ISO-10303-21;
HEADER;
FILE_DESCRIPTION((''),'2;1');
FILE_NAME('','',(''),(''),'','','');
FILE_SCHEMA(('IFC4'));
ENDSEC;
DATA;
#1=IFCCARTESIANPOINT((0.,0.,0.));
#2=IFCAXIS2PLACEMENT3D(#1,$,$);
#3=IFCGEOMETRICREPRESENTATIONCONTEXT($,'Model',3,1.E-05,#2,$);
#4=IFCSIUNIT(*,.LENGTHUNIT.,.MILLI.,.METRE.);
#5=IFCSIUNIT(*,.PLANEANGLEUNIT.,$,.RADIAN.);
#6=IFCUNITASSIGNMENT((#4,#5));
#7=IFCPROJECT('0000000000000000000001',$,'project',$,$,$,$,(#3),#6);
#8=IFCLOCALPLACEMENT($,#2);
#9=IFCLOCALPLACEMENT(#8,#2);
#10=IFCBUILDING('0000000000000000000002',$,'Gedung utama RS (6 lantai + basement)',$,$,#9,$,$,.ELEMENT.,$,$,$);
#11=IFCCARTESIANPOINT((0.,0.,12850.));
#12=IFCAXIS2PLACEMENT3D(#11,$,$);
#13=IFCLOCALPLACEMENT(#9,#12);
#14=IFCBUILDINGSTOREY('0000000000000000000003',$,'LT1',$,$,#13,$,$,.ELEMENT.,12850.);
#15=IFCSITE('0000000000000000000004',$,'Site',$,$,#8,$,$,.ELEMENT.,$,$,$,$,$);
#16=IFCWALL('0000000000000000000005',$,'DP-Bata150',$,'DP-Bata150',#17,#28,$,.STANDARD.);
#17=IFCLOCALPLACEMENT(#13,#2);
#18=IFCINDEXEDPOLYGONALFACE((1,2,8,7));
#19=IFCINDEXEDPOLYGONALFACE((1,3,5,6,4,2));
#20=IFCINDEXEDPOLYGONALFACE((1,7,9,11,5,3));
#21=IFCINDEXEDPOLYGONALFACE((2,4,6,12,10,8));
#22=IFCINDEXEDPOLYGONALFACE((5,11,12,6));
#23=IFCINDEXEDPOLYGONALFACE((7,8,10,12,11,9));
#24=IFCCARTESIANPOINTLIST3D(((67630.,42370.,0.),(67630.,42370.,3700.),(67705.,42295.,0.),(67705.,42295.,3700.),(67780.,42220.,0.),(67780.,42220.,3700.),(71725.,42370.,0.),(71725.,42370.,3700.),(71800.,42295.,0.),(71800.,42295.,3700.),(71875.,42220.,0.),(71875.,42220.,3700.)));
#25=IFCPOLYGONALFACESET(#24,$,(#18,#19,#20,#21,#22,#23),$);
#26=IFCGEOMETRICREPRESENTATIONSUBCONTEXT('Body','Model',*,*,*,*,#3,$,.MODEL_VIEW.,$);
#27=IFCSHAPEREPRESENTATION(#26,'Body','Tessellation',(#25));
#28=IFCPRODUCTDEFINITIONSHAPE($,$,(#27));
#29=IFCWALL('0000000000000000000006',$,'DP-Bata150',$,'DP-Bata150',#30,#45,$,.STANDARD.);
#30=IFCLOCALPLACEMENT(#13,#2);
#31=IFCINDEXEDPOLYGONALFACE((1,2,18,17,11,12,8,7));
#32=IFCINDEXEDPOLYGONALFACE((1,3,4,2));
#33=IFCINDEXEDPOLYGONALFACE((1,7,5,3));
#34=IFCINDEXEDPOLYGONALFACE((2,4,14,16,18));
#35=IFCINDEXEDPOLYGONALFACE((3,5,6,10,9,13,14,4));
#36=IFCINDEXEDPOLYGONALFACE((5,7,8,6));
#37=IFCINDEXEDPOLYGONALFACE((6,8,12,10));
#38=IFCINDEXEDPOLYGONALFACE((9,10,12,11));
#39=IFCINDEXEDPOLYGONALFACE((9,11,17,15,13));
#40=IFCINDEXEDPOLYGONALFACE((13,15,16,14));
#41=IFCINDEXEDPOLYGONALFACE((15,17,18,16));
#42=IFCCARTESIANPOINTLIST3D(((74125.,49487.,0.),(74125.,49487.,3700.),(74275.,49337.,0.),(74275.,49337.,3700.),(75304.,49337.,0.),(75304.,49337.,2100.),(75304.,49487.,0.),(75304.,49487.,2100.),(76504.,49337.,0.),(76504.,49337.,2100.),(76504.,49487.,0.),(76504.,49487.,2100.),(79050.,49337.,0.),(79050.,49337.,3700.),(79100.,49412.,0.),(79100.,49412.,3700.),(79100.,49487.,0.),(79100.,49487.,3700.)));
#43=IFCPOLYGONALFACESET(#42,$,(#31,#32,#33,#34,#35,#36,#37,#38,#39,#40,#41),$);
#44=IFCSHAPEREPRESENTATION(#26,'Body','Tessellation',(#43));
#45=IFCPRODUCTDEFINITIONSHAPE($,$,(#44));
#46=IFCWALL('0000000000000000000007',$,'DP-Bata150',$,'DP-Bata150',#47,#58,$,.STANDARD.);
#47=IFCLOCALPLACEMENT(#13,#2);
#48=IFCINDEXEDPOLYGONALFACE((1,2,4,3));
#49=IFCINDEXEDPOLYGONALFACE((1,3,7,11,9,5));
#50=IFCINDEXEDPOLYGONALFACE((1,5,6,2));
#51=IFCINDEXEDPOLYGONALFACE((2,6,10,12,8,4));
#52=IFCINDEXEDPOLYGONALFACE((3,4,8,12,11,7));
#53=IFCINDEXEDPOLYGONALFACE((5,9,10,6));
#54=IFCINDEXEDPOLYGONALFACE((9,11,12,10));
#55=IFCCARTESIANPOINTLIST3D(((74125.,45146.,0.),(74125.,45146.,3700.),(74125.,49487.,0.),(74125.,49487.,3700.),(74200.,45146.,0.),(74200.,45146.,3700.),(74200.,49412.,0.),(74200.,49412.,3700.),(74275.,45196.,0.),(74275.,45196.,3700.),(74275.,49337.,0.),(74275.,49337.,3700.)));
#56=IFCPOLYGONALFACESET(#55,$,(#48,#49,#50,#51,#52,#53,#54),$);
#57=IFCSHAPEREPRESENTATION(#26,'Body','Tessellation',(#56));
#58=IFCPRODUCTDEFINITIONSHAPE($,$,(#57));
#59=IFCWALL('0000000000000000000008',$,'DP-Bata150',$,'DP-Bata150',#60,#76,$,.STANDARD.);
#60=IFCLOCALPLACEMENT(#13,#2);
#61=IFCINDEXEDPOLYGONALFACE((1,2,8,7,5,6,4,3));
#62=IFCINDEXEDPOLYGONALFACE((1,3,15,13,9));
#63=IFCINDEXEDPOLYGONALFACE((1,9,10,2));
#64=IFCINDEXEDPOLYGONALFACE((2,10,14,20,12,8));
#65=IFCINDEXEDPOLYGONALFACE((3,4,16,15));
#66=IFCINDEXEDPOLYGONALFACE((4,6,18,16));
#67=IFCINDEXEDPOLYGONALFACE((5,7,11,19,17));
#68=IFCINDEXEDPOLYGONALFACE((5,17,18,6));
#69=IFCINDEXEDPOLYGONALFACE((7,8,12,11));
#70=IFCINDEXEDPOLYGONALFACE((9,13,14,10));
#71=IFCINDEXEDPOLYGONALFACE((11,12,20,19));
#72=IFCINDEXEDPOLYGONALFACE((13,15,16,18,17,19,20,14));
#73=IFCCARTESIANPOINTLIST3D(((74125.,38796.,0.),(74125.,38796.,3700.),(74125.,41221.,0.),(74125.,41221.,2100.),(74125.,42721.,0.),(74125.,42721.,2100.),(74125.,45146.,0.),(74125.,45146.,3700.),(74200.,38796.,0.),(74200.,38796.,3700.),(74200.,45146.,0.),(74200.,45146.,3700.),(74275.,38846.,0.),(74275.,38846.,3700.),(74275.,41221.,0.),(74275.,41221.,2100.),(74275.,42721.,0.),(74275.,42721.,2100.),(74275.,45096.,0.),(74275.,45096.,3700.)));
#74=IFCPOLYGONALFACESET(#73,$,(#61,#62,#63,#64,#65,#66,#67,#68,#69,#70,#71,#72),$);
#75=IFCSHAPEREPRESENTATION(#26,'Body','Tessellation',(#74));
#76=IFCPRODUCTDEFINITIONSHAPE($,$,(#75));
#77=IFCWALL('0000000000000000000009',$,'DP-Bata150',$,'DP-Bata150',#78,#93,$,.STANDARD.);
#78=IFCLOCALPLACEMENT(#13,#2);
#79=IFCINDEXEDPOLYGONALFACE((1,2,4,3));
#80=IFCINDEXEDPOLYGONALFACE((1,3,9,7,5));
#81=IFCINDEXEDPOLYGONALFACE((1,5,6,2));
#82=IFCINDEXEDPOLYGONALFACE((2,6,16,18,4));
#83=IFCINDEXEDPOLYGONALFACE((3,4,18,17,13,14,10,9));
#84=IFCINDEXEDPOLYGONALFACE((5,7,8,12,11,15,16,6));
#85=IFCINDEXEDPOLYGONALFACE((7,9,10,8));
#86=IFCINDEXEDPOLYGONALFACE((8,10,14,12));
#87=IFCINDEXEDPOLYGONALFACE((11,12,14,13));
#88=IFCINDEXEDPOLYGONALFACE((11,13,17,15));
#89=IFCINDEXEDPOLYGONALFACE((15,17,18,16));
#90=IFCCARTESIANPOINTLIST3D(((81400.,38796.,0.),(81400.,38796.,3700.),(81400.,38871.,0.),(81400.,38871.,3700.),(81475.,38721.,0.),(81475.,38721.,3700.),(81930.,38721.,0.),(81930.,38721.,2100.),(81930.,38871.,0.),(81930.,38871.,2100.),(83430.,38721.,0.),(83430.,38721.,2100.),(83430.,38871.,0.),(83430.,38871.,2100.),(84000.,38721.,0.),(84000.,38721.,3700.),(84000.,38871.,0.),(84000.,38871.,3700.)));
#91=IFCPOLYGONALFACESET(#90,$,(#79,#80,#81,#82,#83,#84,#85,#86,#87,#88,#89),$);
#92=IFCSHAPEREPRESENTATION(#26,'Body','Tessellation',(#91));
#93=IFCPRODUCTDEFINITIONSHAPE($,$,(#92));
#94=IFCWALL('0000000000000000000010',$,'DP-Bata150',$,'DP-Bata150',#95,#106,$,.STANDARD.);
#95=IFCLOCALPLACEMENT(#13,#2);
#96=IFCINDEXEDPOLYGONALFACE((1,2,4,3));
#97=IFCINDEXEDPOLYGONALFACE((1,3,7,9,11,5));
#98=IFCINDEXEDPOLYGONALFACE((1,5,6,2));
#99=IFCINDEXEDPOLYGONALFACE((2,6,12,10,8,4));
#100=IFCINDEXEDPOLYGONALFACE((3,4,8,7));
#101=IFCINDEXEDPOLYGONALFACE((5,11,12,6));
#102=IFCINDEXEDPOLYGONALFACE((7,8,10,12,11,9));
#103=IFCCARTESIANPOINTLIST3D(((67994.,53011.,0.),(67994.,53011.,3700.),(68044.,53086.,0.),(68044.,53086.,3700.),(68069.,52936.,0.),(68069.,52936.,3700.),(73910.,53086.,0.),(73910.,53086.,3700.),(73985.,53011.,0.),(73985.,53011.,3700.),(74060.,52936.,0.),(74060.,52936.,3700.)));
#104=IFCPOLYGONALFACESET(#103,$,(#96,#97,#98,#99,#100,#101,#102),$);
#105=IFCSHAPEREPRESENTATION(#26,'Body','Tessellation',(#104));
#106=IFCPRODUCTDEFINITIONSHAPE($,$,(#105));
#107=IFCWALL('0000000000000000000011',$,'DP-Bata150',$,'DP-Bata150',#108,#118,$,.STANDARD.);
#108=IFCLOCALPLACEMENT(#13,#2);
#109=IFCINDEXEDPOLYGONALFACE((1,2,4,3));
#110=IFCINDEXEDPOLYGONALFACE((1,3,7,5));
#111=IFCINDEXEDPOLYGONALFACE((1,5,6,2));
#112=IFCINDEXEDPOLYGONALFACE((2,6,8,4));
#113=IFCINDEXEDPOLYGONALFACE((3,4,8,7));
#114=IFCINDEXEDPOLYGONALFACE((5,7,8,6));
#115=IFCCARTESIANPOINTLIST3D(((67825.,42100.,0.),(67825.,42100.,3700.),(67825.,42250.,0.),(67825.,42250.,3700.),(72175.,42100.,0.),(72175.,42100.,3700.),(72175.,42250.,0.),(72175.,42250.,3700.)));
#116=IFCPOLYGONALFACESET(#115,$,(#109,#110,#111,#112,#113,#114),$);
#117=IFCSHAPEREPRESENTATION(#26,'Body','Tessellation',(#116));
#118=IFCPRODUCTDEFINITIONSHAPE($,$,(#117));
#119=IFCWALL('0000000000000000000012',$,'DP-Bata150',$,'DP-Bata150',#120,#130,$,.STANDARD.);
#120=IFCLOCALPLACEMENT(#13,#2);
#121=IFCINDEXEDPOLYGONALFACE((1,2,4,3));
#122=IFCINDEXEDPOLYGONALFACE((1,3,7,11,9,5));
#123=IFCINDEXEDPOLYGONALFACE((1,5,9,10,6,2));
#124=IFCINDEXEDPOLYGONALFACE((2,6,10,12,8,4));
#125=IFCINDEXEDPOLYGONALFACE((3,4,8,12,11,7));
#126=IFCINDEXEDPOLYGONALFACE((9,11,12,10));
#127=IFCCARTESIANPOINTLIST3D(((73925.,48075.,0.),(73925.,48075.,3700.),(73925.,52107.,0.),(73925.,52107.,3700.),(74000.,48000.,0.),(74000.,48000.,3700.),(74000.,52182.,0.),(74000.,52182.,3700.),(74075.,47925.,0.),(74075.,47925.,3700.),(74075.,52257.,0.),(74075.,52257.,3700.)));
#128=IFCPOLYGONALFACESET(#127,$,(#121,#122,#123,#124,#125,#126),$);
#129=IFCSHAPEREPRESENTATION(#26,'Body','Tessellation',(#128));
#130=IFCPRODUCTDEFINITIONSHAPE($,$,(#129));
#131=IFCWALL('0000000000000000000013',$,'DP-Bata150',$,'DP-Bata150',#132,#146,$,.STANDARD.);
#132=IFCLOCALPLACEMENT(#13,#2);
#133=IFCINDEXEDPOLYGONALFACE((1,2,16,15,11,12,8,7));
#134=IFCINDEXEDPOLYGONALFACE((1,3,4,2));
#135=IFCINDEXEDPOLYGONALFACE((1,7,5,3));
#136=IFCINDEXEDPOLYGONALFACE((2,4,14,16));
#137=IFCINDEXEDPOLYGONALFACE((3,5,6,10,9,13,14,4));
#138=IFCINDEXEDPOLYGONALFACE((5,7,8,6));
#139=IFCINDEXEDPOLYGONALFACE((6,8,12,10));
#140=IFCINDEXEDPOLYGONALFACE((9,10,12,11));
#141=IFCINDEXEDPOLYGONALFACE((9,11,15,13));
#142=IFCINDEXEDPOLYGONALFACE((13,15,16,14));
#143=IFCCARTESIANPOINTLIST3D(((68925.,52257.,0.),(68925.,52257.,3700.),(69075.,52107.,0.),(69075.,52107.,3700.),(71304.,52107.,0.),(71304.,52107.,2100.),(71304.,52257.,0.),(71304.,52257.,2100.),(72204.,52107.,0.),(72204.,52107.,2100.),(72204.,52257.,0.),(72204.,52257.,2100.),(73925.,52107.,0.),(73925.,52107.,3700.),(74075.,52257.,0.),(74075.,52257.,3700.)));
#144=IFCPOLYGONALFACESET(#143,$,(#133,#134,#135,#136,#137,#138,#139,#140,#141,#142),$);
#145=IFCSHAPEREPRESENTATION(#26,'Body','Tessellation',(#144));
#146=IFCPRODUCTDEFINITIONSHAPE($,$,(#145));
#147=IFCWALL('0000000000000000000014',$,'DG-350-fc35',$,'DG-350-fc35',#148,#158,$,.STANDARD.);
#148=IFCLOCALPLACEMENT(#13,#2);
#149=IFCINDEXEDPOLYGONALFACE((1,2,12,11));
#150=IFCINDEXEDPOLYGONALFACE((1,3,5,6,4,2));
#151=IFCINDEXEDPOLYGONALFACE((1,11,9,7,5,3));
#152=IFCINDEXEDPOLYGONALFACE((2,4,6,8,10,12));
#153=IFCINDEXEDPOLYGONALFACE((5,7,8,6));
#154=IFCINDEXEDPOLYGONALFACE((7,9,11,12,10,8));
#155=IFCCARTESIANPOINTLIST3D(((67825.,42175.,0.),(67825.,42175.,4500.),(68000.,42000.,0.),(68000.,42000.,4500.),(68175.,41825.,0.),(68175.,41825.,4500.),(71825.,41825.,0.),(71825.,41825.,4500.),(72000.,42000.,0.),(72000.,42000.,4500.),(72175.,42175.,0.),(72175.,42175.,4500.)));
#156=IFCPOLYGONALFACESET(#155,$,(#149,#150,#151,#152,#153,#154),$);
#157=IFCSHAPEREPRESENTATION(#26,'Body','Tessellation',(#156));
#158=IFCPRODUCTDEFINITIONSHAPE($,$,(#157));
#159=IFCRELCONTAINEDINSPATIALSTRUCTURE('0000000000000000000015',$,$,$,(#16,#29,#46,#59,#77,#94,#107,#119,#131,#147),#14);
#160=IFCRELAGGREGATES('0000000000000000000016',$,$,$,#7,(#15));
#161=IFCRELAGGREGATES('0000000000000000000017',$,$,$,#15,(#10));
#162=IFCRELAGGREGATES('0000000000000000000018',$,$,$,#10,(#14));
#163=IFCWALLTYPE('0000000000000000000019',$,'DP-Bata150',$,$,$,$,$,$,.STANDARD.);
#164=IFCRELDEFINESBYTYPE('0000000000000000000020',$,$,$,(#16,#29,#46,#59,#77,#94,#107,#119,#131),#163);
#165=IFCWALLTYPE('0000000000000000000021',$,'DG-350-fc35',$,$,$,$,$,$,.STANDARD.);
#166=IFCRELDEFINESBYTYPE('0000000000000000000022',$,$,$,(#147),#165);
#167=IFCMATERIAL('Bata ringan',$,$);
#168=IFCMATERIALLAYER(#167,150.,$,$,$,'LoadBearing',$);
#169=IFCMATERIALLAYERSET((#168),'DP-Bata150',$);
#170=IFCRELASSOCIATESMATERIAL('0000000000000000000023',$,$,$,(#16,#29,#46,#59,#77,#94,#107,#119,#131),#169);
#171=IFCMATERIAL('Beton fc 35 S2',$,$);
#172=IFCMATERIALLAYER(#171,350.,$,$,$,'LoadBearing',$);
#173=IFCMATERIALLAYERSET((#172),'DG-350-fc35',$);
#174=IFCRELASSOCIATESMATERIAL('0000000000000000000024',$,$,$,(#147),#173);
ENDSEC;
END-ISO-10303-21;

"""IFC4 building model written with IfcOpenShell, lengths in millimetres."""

from ifc_helpers import new_model, si_unit, frame, frame_2d, origin, place, context, subcontext, project, spatial, polyline, rectangle, outline, extrude, material, layer, layer_set, layer_usage, type_object, element, save


model = new_model("IFC4")

# Units and contexts
model_context = context("Model", 3, precision=1e-05, world=origin())
body_context = subcontext(model_context, "Body", "Model", "MODEL_VIEW")
ifc_project = project(units=[si_unit("LENGTHUNIT", "METRE", prefix="MILLI"), si_unit("PLANEANGLEUNIT", "RADIAN")], contexts=[model_context])

# Site, building, storey
site_placement = place(None, origin())
site = spatial("IfcSite", under=ifc_project, at=site_placement, Name="Site", CompositionType="ELEMENT")
building_placement = place(site_placement, origin())
building = spatial("IfcBuilding", under=site, at=building_placement, Name="Gedung utama RS (6 lantai + basement)", CompositionType="ELEMENT")
storey_placement = place(building_placement, frame((0.0, 0.0, 12850.0)))
storey = spatial("IfcBuildingStorey", under=building, at=storey_placement, Name="LT1", CompositionType="ELEMENT", Elevation=12850.0)

# Shared definitions
ifc_material_1 = material(Name="Beton fc 35 S2")

# Shared definitions
ifc_material_2 = material(Name="Bata ringan")

# Shared definitions
ifc_layer_1 = layer(ifc_material_2, 150.0, Category="LoadBearing")
ifc_layer_set_1 = layer_set([ifc_layer_1], Name="DP-Bata150")
ifc_layer_usage_1 = layer_usage(ifc_layer_set_1, "AXIS2", "NEGATIVE", 75.0)
wall_type_1 = type_object("IfcWallType", Name="DP-Bata150", PredefinedType="STANDARD")

# Wall
wall_1_placement = place(storey_placement, frame((71800.0, 42295.0, 0.0), z_axis=(0.0, 0.0, 1.0), x_axis=(-1.0, 0.0, 0.0)))
element("IfcWall", 1, at=wall_1_placement, inside=storey, type_object=wall_type_1, material=ifc_layer_usage_1, Name="DP-Bata150", ObjectType="DP-Bata150", PredefinedType="STANDARD", context=body_context, shape_type="SweptSolid", body=[
    extrude(outline(polyline([(75.0, -75.0), (0.0, 0.0), (-75.0, 75.0), (4020.0, 75.0), (4095.0, 0.0), (4170.0, -75.0), (75.0, -75.0)])), origin(), (0.0, 0.0, 1.0), 3700.0),
])

# Wall, opening
wall_2_placement = place(storey_placement, frame((79100.0, 49412.0, 0.0), z_axis=(0.0, 0.0, 1.0), x_axis=(-1.0, 0.0, 0.0)))
wall_2 = element("IfcWall", 2, at=wall_2_placement, inside=storey, type_object=wall_type_1, material=ifc_layer_usage_1, Name="DP-Bata150", ObjectType="DP-Bata150", PredefinedType="STANDARD", context=body_context, shape_type="SweptSolid", body=[
    extrude(outline(polyline([(0.0, -75.0), (0.0, 0.0), (50.0, 75.0), (4825.0, 75.0), (4900.0, 0.0), (4975.0, -75.0), (0.0, -75.0)])), origin(), (0.0, 0.0, 1.0), 3700.0),
])
opening_1_placement = place(wall_2_placement, frame((2596.0, 0.0, 0.0), z_axis=(0.0, 0.0, 1.0), x_axis=(1.0, 0.0, 0.0)))
element("IfcOpeningElement", 3, at=opening_1_placement, cuts=wall_2, PredefinedType="OPENING", context=body_context, shape_type="SweptSolid", body=[
    extrude(rectangle(XDim=1200.0, YDim=170.0, at=frame_2d((600.0, 0.0))), origin(), (0.0, 0.0, 1.0), 2100.0),
])

# Wall
wall_3_placement = place(storey_placement, frame((74200.0, 49412.0, 0.0), z_axis=(0.0, 0.0, 1.0), x_axis=(0.0, -1.0, 0.0)))
element("IfcWall", 4, at=wall_3_placement, inside=storey, type_object=wall_type_1, material=ifc_layer_usage_1, Name="DP-Bata150", ObjectType="DP-Bata150", PredefinedType="STANDARD", context=body_context, shape_type="SweptSolid", body=[
    extrude(outline(polyline([(-75.0, -75.0), (0.0, 0.0), (75.0, 75.0), (4216.0, 75.0), (4266.0, 0.0), (4266.0, -75.0), (-75.0, -75.0)])), origin(), (0.0, 0.0, 1.0), 3700.0),
])

# Walls, openings
wall_4_placement = place(storey_placement, frame((74200.0, 45146.0, 0.0), z_axis=(0.0, 0.0, 1.0), x_axis=(0.0, -1.0, 0.0)))
wall_4 = element("IfcWall", 5, at=wall_4_placement, inside=storey, type_object=wall_type_1, material=ifc_layer_usage_1, Name="DP-Bata150", ObjectType="DP-Bata150", PredefinedType="STANDARD", context=body_context, shape_type="SweptSolid", body=[
    extrude(outline(polyline([(0.0, -75.0), (0.0, 0.0), (50.0, 75.0), (6300.0, 75.0), (6350.0, 0.0), (6350.0, -75.0), (0.0, -75.0)])), origin(), (0.0, 0.0, 1.0), 3700.0),
])
opening_2_placement = place(wall_4_placement, frame((2425.0, 0.0, 0.0), z_axis=(0.0, 0.0, 1.0), x_axis=(1.0, 0.0, 0.0)))
element("IfcOpeningElement", 6, at=opening_2_placement, cuts=wall_4, PredefinedType="OPENING", context=body_context, shape_type="SweptSolid", body=[
    extrude(rectangle(XDim=1500.0, YDim=170.0, at=frame_2d((750.0, 0.0))), origin(), (0.0, 0.0, 1.0), 2100.0),
])
wall_5_placement = place(storey_placement, frame((81400.0, 38796.0, 0.0), z_axis=(0.0, 0.0, 1.0), x_axis=(1.0, 0.0, 0.0)))
wall_5 = element("IfcWall", 7, at=wall_5_placement, inside=storey, type_object=wall_type_1, material=ifc_layer_usage_1, Name="DP-Bata150", ObjectType="DP-Bata150", PredefinedType="STANDARD", context=body_context, shape_type="SweptSolid", body=[
    extrude(outline(polyline([(75.0, -75.0), (0.0, 0.0), (0.0, 75.0), (2600.0, 75.0), (2600.0, -75.0), (75.0, -75.0)])), origin(), (0.0, 0.0, 1.0), 3700.0),
])
opening_3_placement = place(wall_5_placement, frame((530.0, 0.0, 0.0), z_axis=(0.0, 0.0, 1.0), x_axis=(1.0, 0.0, 0.0)))
element("IfcOpeningElement", 8, at=opening_3_placement, cuts=wall_5, PredefinedType="OPENING", context=body_context, shape_type="SweptSolid", body=[
    extrude(rectangle(XDim=1500.0, YDim=170.0, at=frame_2d((750.0, 0.0))), origin(), (0.0, 0.0, 1.0), 2100.0),
])

# Walls
wall_6_placement = place(storey_placement, frame((73985.0, 53011.0, 0.0), z_axis=(0.0, 0.0, 1.0), x_axis=(-1.0, 0.0, 0.0)))
element("IfcWall", 9, at=wall_6_placement, inside=storey, type_object=wall_type_1, material=ifc_layer_usage_1, Name="DP-Bata150", ObjectType="DP-Bata150", PredefinedType="STANDARD", context=body_context, shape_type="SweptSolid", body=[
    extrude(outline(polyline([(75.0, -75.0), (0.0, 0.0), (-75.0, 75.0), (5916.0, 75.0), (5991.0, 0.0), (5941.0, -75.0), (75.0, -75.0)])), origin(), (0.0, 0.0, 1.0), 3700.0),
])
wall_7_placement = place(storey_placement, frame((72175.0, 42175.0, 0.0), z_axis=(0.0, 0.0, 1.0), x_axis=(-1.0, 0.0, 0.0)))
element("IfcWall", 10, at=wall_7_placement, inside=storey, type_object=wall_type_1, material=ifc_layer_usage_1, Name="DP-Bata150", ObjectType="DP-Bata150", PredefinedType="STANDARD", context=body_context, shape_type="SweptSolid", body=[
    extrude(outline(polyline([(0.0, -75.0), (0.0, 75.0), (4350.0, 75.0), (4350.0, -75.0), (0.0, -75.0)])), origin(), (0.0, 0.0, 1.0), 3700.0),
])
wall_8_placement = place(storey_placement, frame((74000.0, 48000.0, 0.0), z_axis=(0.0, 0.0, 1.0), x_axis=(0.0, 1.0, 0.0)))
element("IfcWall", 11, at=wall_8_placement, inside=storey, type_object=wall_type_1, material=ifc_layer_usage_1, Name="DP-Bata150", ObjectType="DP-Bata150", PredefinedType="STANDARD", context=body_context, shape_type="SweptSolid", body=[
    extrude(outline(polyline([(-75.0, -75.0), (0.0, 0.0), (75.0, 75.0), (4107.0, 75.0), (4182.0, 0.0), (4257.0, -75.0), (-75.0, -75.0)])), origin(), (0.0, 0.0, 1.0), 3700.0),
])

# Wall, opening
wall_9_placement = place(storey_placement, frame((74000.0, 52182.0, 0.0), z_axis=(0.0, 0.0, 1.0), x_axis=(-1.0, 0.0, 0.0)))
wall_9 = element("IfcWall", 12, at=wall_9_placement, inside=storey, type_object=wall_type_1, material=ifc_layer_usage_1, Name="DP-Bata150", ObjectType="DP-Bata150", PredefinedType="STANDARD", context=body_context, shape_type="SweptSolid", body=[
    extrude(outline(polyline([(-75.0, -75.0), (0.0, 0.0), (75.0, 75.0), (4925.0, 75.0), (5000.0, 0.0), (5075.0, -75.0), (-75.0, -75.0)])), origin(), (0.0, 0.0, 1.0), 3700.0),
])
opening_4_placement = place(wall_9_placement, frame((1796.0, 0.0, 0.0), z_axis=(0.0, 0.0, 1.0), x_axis=(1.0, 0.0, 0.0)))
element("IfcOpeningElement", 13, at=opening_4_placement, cuts=wall_9, PredefinedType="OPENING", context=body_context, shape_type="SweptSolid", body=[
    extrude(rectangle(XDim=900.0, YDim=170.0, at=frame_2d((450.0, 0.0))), origin(), (0.0, 0.0, 1.0), 2100.0),
])

# Wall
ifc_layer_2 = layer(ifc_material_1, 350.0, Category="LoadBearing")
ifc_layer_set_2 = layer_set([ifc_layer_2], Name="DG-350-fc35")
ifc_layer_usage_2 = layer_usage(ifc_layer_set_2, "AXIS2", "NEGATIVE", 175.0)
wall_type_2 = type_object("IfcWallType", Name="DG-350-fc35", PredefinedType="STANDARD")
wall_10_placement = place(storey_placement, frame((72000.0, 42000.0, 0.0), z_axis=(0.0, 0.0, 1.0), x_axis=(-1.0, 0.0, 0.0)))
element("IfcWall", 14, at=wall_10_placement, inside=storey, type_object=wall_type_2, material=ifc_layer_usage_2, Name="DG-350-fc35", ObjectType="DG-350-fc35", PredefinedType="STANDARD", context=body_context, shape_type="SweptSolid", body=[
    extrude(outline(polyline([(-175.0, -175.0), (0.0, 0.0), (175.0, 175.0), (3825.0, 175.0), (4000.0, 0.0), (4175.0, -175.0), (-175.0, -175.0)])), origin(), (0.0, 0.0, 1.0), 4500.0),
])

save(model, "model.ifc")
